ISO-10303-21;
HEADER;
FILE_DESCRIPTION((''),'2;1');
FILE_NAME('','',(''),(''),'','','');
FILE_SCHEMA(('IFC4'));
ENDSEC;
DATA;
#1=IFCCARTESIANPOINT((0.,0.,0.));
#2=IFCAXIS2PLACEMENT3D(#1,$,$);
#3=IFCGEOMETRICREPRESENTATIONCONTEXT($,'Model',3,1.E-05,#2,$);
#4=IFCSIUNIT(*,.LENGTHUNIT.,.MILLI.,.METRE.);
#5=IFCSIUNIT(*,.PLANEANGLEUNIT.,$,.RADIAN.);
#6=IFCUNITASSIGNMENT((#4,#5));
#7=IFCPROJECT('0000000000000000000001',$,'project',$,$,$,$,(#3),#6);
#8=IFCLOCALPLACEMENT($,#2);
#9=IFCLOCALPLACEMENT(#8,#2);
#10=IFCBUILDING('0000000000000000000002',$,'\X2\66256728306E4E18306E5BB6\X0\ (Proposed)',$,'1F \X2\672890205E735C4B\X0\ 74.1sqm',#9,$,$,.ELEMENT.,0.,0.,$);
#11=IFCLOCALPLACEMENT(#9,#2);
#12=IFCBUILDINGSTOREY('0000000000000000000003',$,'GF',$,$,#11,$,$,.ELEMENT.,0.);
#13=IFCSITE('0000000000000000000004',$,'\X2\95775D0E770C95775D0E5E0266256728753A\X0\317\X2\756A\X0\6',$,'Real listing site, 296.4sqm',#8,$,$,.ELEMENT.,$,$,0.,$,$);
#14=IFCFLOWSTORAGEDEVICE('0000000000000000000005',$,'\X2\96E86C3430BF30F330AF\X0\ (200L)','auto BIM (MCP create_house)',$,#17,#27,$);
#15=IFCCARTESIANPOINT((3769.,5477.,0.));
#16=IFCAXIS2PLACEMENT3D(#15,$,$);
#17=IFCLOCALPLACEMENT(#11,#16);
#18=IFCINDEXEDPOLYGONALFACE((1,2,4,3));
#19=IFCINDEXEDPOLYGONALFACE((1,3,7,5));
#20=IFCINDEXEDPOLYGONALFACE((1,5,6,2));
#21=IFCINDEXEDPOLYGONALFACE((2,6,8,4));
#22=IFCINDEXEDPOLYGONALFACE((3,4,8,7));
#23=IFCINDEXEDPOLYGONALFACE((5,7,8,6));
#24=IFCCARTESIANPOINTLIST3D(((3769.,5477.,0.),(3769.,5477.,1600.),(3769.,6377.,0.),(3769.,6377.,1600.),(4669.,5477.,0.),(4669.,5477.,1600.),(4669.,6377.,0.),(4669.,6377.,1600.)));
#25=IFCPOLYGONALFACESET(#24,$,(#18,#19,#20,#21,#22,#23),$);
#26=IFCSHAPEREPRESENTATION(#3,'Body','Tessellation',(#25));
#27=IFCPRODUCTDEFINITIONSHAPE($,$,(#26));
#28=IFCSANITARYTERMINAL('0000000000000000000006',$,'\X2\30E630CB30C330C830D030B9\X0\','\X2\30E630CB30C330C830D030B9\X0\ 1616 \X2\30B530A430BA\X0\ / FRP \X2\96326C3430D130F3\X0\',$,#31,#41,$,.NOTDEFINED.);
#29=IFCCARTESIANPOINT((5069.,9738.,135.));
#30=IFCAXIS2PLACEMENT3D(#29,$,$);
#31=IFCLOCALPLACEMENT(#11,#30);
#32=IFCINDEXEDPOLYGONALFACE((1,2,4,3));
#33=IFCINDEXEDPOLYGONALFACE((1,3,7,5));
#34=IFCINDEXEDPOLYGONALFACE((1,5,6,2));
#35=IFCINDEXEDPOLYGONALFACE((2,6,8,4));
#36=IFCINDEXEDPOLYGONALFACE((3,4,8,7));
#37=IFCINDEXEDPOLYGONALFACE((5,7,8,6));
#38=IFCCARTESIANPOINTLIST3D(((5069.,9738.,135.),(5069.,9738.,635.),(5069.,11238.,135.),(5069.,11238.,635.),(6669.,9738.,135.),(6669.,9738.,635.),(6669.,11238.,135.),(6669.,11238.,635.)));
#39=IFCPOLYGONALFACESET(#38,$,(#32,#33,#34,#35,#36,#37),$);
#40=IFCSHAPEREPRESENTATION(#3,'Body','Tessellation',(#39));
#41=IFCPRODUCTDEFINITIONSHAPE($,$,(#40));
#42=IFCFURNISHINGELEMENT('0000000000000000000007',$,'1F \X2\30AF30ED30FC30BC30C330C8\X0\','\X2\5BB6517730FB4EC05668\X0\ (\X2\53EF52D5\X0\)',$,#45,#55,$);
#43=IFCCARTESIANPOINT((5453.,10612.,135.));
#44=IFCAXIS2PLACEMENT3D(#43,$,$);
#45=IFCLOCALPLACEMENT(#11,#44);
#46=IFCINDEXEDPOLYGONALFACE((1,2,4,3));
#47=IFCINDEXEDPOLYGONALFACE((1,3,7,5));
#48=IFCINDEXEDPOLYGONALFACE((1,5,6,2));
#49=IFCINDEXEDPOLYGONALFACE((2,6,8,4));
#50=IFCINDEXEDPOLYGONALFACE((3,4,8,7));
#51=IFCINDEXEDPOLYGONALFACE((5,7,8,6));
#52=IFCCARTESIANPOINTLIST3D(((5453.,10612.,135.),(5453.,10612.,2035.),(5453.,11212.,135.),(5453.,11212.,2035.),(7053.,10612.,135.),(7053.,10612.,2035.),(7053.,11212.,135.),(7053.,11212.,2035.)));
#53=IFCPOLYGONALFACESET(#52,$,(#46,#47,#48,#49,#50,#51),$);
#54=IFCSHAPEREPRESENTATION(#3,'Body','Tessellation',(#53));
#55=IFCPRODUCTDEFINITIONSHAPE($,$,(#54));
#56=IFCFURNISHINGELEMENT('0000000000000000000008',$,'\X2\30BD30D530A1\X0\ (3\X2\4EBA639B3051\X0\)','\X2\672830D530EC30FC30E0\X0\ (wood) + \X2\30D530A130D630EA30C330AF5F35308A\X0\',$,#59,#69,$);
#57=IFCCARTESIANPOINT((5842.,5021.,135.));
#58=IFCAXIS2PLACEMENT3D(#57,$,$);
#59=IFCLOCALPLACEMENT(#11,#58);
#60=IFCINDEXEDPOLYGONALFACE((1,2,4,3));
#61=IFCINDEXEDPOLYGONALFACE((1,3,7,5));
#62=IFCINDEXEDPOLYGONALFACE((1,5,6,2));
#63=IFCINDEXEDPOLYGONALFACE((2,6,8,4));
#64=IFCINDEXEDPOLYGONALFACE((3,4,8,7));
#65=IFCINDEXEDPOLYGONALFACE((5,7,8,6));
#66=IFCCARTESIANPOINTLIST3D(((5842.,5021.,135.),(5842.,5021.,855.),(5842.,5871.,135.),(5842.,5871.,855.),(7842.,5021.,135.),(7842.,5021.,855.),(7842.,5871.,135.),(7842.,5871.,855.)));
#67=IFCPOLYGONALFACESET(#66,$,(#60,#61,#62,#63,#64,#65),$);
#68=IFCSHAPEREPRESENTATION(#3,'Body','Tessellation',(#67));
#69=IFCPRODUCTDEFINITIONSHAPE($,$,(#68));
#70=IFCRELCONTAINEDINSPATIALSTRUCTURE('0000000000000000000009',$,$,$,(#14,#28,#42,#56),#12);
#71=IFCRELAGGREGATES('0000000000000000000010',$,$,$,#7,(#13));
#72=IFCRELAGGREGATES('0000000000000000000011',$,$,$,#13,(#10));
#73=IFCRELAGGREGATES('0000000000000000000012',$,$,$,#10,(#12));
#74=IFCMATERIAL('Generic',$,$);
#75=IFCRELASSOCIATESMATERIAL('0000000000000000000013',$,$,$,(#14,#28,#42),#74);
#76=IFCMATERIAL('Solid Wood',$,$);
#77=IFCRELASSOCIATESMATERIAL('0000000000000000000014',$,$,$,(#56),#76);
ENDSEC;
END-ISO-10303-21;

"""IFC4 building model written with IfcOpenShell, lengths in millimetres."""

from ifc_helpers import new_model, si_unit, frame, frame_2d, origin, place, context, project, spatial, rectangle, extrude, material, element, save


model = new_model("IFC4")

# Units and contexts
model_context = context("Model", 3, precision=1e-05, world=origin())
ifc_project = project(units=[si_unit("LENGTHUNIT", "METRE", prefix="MILLI"), si_unit("PLANEANGLEUNIT", "RADIAN")], contexts=[model_context])

# Site, building, storey
site_placement = place(None, origin())
site = spatial("IfcSite", under=ifc_project, at=site_placement, Name="長崎県長崎市春木町317番6", ObjectType="Real listing site, 296.4sqm", CompositionType="ELEMENT", RefElevation=0.0)
building_placement = place(site_placement, origin())
building = spatial("IfcBuilding", under=site, at=building_placement, Name="春木の丘の家 (Proposed)", ObjectType="1F 木造平屋 74.1sqm", CompositionType="ELEMENT", ElevationOfRefHeight=0.0, ElevationOfTerrain=0.0)
storey_placement = place(building_placement, origin())
storey = spatial("IfcBuildingStorey", under=building, at=storey_placement, Name="GF", CompositionType="ELEMENT", Elevation=0.0)

# Shared definitions
ifc_material_1 = material(Name="Solid Wood")

# Shared definitions
ifc_material_2 = material(Name="Generic")

# Flow storage device
flow_storage_device_placement = place(storey_placement, frame((3769.0, 5477.0, 0.0)))
element("IfcFlowStorageDevice", 1, at=flow_storage_device_placement, inside=storey, material=ifc_material_2, Name="雨水タンク (200L)", Description="auto BIM (MCP create_house)", context=model_context, shape_type="SweptSolid", body=[
    extrude(rectangle(XDim=900.0, YDim=900.0, at=frame_2d((450.0, 450.0))), frame((3769.0, 5477.0, 0.0)), (0.0, 0.0, 1.0), 1600.0),
])

# Sanitary terminal
sanitary_terminal_placement = place(storey_placement, frame((5069.0, 9738.0, 135.0)))
element("IfcSanitaryTerminal", 2, at=sanitary_terminal_placement, inside=storey, material=ifc_material_2, Name="ユニットバス", Description="ユニットバス 1616 サイズ / FRP 防水パン", PredefinedType="NOTDEFINED", context=model_context, shape_type="SweptSolid", body=[
    extrude(rectangle(XDim=1600.0, YDim=1500.0, at=frame_2d((800.0, 750.0))), frame((5069.0, 9738.0, 135.0)), (0.0, 0.0, 1.0), 500.0),
])

# Furnishing elements
furnishing_1_placement = place(storey_placement, frame((5453.0, 10612.0, 135.0)))
element("IfcFurnishingElement", 3, at=furnishing_1_placement, inside=storey, material=ifc_material_2, Name="1F クローゼット", Description="家具・什器 (可動)", context=model_context, shape_type="SweptSolid", body=[
    extrude(rectangle(XDim=1600.0, YDim=600.0, at=frame_2d((800.0, 300.0))), frame((5453.0, 10612.0, 135.0)), (0.0, 0.0, 1.0), 1900.0),
])
furnishing_2_placement = place(storey_placement, frame((5842.0, 5021.0, 135.0)))
element("IfcFurnishingElement", 4, at=furnishing_2_placement, inside=storey, material=ifc_material_1, Name="ソファ (3人掛け)", Description="木フレーム (wood) + ファブリック張り", context=model_context, shape_type="SweptSolid", body=[
    extrude(rectangle(XDim=2000.0, YDim=850.0, at=frame_2d((1000.0, 425.0))), frame((5842.0, 5021.0, 135.0)), (0.0, 0.0, 1.0), 720.0),
])

save(model, "model.ifc")
